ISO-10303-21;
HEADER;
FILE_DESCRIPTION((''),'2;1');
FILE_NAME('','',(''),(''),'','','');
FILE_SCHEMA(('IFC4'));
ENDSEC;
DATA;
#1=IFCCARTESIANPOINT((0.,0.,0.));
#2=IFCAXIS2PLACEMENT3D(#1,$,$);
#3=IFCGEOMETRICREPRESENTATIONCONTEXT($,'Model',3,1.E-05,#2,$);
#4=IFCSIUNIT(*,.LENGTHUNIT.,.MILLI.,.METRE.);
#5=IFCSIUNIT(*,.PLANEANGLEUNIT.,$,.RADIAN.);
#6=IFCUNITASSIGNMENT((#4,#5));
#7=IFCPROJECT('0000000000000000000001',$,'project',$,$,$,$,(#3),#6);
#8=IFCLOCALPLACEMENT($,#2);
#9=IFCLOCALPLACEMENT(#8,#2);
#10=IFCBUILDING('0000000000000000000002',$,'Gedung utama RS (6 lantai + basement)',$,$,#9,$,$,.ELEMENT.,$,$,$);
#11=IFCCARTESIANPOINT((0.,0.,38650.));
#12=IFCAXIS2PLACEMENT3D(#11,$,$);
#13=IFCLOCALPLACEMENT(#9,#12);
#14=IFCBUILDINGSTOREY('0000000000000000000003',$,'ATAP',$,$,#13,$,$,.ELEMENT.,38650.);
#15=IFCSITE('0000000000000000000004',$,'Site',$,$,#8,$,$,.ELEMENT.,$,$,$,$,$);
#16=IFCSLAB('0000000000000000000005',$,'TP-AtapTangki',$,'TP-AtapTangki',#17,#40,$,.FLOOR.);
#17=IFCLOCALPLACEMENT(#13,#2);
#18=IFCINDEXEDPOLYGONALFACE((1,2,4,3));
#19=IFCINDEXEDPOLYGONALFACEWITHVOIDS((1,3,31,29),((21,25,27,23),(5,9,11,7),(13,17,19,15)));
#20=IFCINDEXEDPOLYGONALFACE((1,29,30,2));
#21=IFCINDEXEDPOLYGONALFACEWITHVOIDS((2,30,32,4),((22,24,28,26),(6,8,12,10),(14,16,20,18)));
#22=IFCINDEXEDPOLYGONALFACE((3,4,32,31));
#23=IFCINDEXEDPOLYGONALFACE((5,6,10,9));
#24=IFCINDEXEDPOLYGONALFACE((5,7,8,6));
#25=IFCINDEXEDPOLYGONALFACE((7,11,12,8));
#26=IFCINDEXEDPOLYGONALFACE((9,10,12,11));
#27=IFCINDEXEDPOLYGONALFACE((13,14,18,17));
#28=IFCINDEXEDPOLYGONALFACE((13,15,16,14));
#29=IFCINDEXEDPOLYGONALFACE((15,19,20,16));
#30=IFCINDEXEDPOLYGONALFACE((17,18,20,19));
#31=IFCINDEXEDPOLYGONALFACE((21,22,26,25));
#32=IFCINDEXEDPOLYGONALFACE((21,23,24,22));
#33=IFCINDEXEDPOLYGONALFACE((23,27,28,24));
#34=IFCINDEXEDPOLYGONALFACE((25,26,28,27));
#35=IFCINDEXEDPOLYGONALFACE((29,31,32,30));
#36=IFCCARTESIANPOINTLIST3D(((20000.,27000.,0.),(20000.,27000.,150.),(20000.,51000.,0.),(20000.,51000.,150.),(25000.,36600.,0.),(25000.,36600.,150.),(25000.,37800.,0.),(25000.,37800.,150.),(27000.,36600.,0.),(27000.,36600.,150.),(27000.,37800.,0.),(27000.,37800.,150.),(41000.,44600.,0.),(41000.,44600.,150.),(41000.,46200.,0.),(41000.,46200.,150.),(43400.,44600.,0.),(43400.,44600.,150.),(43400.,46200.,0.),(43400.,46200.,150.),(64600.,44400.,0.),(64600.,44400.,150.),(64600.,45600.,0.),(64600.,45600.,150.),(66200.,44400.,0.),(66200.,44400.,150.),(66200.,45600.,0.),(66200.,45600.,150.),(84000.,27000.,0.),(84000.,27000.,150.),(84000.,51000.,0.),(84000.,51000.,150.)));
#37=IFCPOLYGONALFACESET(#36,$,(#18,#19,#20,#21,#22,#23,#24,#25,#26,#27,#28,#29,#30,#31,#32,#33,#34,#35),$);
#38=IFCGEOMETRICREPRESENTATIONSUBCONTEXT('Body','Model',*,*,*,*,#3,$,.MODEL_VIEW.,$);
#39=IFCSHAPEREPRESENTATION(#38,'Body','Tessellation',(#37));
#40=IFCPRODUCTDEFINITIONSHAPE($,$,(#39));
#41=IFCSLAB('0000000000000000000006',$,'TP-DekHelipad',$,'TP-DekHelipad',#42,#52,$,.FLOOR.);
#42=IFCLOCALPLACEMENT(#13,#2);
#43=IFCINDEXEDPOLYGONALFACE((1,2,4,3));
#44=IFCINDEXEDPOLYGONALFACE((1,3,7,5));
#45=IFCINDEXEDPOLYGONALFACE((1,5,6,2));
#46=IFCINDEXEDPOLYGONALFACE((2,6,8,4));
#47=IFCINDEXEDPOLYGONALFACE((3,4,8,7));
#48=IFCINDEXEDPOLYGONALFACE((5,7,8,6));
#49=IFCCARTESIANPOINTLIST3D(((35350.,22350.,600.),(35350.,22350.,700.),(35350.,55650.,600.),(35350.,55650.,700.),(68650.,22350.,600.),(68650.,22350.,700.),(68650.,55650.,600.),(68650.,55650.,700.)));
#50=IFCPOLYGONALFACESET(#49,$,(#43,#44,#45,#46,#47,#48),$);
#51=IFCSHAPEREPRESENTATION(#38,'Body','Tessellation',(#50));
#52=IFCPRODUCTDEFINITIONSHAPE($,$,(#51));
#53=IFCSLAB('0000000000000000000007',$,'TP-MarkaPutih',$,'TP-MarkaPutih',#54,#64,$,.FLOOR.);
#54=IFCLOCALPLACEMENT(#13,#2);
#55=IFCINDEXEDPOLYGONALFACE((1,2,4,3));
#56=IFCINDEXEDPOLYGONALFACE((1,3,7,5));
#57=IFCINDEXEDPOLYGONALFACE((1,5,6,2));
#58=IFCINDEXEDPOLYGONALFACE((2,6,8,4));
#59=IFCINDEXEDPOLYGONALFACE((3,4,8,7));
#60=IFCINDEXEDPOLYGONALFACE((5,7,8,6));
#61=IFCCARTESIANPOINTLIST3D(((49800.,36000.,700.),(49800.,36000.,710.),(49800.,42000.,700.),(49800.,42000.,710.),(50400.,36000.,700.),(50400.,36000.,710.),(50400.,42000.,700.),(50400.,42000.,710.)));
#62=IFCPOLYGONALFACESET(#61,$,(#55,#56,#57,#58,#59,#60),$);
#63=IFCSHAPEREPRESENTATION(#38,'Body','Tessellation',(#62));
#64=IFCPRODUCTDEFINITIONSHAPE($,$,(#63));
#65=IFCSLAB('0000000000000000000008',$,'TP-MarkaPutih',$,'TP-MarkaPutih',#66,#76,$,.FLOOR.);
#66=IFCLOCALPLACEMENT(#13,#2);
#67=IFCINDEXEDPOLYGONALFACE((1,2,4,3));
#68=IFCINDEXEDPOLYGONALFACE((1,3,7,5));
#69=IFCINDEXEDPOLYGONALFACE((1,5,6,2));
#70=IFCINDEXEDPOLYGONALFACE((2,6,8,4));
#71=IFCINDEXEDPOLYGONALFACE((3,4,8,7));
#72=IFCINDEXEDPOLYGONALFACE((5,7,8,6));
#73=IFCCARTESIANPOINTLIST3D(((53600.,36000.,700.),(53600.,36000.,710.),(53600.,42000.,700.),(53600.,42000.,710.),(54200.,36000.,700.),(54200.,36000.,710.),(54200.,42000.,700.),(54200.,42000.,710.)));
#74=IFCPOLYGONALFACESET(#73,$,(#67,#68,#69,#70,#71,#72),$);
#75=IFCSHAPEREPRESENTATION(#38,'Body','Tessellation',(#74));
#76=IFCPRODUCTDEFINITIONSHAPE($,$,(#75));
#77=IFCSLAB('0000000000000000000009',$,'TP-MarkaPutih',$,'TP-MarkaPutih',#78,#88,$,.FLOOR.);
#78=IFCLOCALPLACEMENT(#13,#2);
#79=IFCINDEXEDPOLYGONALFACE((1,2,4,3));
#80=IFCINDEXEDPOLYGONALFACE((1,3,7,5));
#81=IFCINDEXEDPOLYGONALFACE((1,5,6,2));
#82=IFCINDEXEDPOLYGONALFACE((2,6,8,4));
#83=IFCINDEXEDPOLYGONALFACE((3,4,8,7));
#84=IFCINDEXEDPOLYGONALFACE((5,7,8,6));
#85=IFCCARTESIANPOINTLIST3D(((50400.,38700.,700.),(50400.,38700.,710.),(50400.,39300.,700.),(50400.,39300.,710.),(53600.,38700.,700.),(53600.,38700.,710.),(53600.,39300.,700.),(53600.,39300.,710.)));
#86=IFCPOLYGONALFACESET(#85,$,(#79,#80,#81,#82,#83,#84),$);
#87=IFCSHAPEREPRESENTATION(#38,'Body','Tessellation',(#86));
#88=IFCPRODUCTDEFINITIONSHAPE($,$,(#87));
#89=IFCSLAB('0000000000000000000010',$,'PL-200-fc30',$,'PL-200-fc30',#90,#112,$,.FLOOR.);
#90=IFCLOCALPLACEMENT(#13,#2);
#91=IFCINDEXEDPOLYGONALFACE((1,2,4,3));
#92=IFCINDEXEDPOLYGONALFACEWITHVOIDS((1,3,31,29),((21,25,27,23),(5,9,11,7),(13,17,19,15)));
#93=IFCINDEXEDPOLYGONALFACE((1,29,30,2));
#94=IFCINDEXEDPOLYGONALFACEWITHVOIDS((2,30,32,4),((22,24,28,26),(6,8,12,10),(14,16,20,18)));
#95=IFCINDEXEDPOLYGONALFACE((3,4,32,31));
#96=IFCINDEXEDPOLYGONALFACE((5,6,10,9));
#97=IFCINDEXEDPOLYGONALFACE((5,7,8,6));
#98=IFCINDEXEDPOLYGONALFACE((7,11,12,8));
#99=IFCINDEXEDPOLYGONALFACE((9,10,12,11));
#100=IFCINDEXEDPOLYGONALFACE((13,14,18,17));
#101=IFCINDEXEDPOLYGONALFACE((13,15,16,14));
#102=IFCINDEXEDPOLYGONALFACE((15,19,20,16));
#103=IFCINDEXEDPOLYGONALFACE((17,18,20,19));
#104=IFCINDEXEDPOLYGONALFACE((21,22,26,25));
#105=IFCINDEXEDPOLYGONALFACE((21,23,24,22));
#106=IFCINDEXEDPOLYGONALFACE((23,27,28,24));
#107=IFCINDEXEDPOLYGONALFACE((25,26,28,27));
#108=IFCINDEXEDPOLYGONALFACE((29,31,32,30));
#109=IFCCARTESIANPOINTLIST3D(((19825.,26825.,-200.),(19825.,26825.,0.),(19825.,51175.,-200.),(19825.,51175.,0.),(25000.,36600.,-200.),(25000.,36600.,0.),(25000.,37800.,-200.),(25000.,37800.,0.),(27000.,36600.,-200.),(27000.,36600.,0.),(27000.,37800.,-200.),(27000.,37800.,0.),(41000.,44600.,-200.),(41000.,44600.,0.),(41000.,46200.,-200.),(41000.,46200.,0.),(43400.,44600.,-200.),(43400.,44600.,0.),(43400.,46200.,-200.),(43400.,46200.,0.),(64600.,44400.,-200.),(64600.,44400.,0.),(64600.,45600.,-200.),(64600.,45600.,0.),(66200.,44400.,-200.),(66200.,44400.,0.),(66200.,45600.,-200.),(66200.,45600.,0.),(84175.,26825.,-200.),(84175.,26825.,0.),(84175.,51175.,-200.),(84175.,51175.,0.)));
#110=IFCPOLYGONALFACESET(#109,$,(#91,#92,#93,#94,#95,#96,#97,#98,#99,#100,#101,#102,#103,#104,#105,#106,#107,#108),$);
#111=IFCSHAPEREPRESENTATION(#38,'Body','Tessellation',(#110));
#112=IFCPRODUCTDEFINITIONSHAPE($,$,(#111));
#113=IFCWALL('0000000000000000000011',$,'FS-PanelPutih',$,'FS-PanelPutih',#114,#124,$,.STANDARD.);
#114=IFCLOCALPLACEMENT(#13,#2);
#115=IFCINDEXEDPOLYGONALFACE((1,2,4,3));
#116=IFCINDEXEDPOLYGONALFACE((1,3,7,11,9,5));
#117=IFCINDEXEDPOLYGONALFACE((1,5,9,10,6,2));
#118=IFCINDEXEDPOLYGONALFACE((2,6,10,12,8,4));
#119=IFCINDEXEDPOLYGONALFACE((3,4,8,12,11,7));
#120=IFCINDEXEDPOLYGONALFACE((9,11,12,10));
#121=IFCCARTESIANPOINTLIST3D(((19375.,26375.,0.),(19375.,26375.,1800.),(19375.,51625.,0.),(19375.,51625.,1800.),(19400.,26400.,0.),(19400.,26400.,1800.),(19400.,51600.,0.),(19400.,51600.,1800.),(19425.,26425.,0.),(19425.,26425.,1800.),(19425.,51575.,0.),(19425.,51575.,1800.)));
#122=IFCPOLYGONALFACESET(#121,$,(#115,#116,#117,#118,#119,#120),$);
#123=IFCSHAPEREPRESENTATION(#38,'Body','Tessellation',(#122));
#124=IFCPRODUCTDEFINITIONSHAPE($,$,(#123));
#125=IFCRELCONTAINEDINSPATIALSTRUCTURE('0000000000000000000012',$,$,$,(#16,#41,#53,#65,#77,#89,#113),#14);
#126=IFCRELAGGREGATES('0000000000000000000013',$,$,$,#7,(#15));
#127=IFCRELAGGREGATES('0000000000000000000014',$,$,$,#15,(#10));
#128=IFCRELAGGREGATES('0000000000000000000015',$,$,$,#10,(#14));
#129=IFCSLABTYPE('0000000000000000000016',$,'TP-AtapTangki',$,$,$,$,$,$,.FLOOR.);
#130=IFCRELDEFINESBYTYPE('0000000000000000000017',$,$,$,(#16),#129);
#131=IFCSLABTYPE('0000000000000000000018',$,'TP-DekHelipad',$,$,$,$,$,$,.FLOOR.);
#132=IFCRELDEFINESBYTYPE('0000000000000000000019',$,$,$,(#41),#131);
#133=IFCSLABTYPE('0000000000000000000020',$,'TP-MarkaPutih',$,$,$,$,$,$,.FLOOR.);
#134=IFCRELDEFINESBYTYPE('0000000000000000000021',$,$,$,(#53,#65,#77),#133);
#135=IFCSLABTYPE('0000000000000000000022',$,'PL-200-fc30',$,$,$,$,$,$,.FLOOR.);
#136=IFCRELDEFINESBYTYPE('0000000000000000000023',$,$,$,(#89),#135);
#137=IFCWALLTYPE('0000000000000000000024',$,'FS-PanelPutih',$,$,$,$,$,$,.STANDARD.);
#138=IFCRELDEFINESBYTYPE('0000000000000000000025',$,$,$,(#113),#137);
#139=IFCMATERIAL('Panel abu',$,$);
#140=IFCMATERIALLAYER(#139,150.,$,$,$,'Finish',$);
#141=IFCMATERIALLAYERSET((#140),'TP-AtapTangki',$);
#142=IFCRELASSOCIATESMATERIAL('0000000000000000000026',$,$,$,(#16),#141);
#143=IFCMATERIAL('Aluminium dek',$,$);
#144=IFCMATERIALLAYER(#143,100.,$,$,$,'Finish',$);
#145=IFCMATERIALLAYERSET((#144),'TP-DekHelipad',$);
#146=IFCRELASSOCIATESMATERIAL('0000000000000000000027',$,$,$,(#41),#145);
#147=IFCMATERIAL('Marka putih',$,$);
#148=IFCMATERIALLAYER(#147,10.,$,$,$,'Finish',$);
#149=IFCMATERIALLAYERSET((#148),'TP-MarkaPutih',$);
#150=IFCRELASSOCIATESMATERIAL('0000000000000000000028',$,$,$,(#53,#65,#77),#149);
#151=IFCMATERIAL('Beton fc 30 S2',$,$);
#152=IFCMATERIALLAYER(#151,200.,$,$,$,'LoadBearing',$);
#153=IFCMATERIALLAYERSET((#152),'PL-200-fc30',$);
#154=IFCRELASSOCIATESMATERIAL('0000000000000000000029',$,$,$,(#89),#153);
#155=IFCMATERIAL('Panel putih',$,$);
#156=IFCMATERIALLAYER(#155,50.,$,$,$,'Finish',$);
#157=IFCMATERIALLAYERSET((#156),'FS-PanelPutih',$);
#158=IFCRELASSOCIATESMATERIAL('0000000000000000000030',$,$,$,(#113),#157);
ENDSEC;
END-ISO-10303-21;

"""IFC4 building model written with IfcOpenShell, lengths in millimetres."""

from ifc_helpers import new_model, si_unit, frame, origin, place, context, subcontext, project, spatial, polyline, outline, extrude, material, layer, layer_set, layer_usage, type_object, element, save


model = new_model("IFC4")

# Units and contexts
model_context = context("Model", 3, precision=1e-05, world=origin())
body_context = subcontext(model_context, "Body", "Model", "MODEL_VIEW")
ifc_project = project(units=[si_unit("LENGTHUNIT", "METRE", prefix="MILLI"), si_unit("PLANEANGLEUNIT", "RADIAN")], contexts=[model_context])

# Site, building, storey
site_placement = place(None, origin())
site = spatial("IfcSite", under=ifc_project, at=site_placement, Name="Site", CompositionType="ELEMENT")
building_placement = place(site_placement, origin())
building = spatial("IfcBuilding", under=site, at=building_placement, Name="Gedung utama RS (6 lantai + basement)", CompositionType="ELEMENT")
storey_placement = place(building_placement, frame((0.0, 0.0, 38650.0)))
storey = spatial("IfcBuildingStorey", under=building, at=storey_placement, Name="ATAP", CompositionType="ELEMENT", Elevation=38650.0)

# Shared definitions
ifc_material_1 = material(Name="Beton fc 30 S2")

# Slabs
ifc_material_2 = material(Name="Panel abu")
ifc_layer_1 = layer(ifc_material_2, 150.0, Category="Finish")
ifc_layer_set_1 = layer_set([ifc_layer_1], Name="TP-AtapTangki")
ifc_layer_usage_1 = layer_usage(ifc_layer_set_1, "AXIS3", "NEGATIVE", 150.0)
slab_type_1 = type_object("IfcSlabType", Name="TP-AtapTangki", PredefinedType="FLOOR")
slab_1_placement = place(storey_placement, origin())
element("IfcSlab", 1, at=slab_1_placement, inside=storey, type_object=slab_type_1, material=ifc_layer_usage_1, Name="TP-AtapTangki", ObjectType="TP-AtapTangki", PredefinedType="FLOOR", context=body_context, shape_type="SweptSolid", body=[
    extrude(outline(polyline([(84000.0, 27000.0), (84000.0, 51000.0), (20000.0, 51000.0), (20000.0, 27000.0), (84000.0, 27000.0)]), holes=[polyline([(27000.0, 36600.0), (27000.0, 37800.0), (25000.0, 37800.0), (25000.0, 36600.0), (27000.0, 36600.0)]), polyline([(43400.0, 44600.0), (43400.0, 46200.0), (41000.0, 46200.0), (41000.0, 44600.0), (43400.0, 44600.0)]), polyline([(66200.0, 44400.0), (66200.0, 45600.0), (64600.0, 45600.0), (64600.0, 44400.0), (66200.0, 44400.0)])]), origin(), (0.0, 0.0, 1.0), 150.0),
])
ifc_material_3 = material(Name="Aluminium dek")
ifc_layer_2 = layer(ifc_material_3, 100.0, Category="Finish")
ifc_layer_set_2 = layer_set([ifc_layer_2], Name="TP-DekHelipad")
ifc_layer_usage_2 = layer_usage(ifc_layer_set_2, "AXIS3", "NEGATIVE", 700.0)
slab_type_2 = type_object("IfcSlabType", Name="TP-DekHelipad", PredefinedType="FLOOR")
slab_2_placement = place(storey_placement, origin())
element("IfcSlab", 2, at=slab_2_placement, inside=storey, type_object=slab_type_2, material=ifc_layer_usage_2, Name="TP-DekHelipad", ObjectType="TP-DekHelipad", PredefinedType="FLOOR", context=body_context, shape_type="SweptSolid", body=[
    extrude(outline(polyline([(68650.0, 22350.0), (68650.0, 55650.0), (35350.0, 55650.0), (35350.0, 22350.0), (68650.0, 22350.0)])), frame((0.0, 0.0, 600.0)), (0.0, 0.0, 1.0), 100.0),
])
ifc_material_4 = material(Name="Marka putih")
ifc_layer_3 = layer(ifc_material_4, 10.0, Category="Finish")
ifc_layer_set_3 = layer_set([ifc_layer_3], Name="TP-MarkaPutih")
ifc_layer_usage_3 = layer_usage(ifc_layer_set_3, "AXIS3", "NEGATIVE", 710.0)
slab_type_3 = type_object("IfcSlabType", Name="TP-MarkaPutih", PredefinedType="FLOOR")
slab_3_placement = place(storey_placement, origin())
element("IfcSlab", 3, at=slab_3_placement, inside=storey, type_object=slab_type_3, material=ifc_layer_usage_3, Name="TP-MarkaPutih", ObjectType="TP-MarkaPutih", PredefinedType="FLOOR", context=body_context, shape_type="SweptSolid", body=[
    extrude(outline(polyline([(50400.0, 36000.0), (50400.0, 42000.0), (49800.0, 42000.0), (49800.0, 36000.0), (50400.0, 36000.0)])), frame((0.0, 0.0, 700.0)), (0.0, 0.0, 1.0), 10.0),
])
slab_4_placement = place(storey_placement, origin())
element("IfcSlab", 4, at=slab_4_placement, inside=storey, type_object=slab_type_3, material=ifc_layer_usage_3, Name="TP-MarkaPutih", ObjectType="TP-MarkaPutih", PredefinedType="FLOOR", context=body_context, shape_type="SweptSolid", body=[
    extrude(outline(polyline([(54200.0, 36000.0), (54200.0, 42000.0), (53600.0, 42000.0), (53600.0, 36000.0), (54200.0, 36000.0)])), frame((0.0, 0.0, 700.0)), (0.0, 0.0, 1.0), 10.0),
])
slab_5_placement = place(storey_placement, origin())
element("IfcSlab", 5, at=slab_5_placement, inside=storey, type_object=slab_type_3, material=ifc_layer_usage_3, Name="TP-MarkaPutih", ObjectType="TP-MarkaPutih", PredefinedType="FLOOR", context=body_context, shape_type="SweptSolid", body=[
    extrude(outline(polyline([(53600.0, 38700.0), (53600.0, 39300.0), (50400.0, 39300.0), (50400.0, 38700.0), (53600.0, 38700.0)])), frame((0.0, 0.0, 700.0)), (0.0, 0.0, 1.0), 10.0),
])

# Slab, openings
ifc_layer_4 = layer(ifc_material_1, 200.0, Category="LoadBearing")
ifc_layer_set_4 = layer_set([ifc_layer_4], Name="PL-200-fc30")
ifc_layer_usage_4 = layer_usage(ifc_layer_set_4, "AXIS3", "NEGATIVE", 0.0)
slab_type_4 = type_object("IfcSlabType", Name="PL-200-fc30", PredefinedType="FLOOR")
slab_6_placement = place(storey_placement, origin())
slab_6 = element("IfcSlab", 6, at=slab_6_placement, inside=storey, type_object=slab_type_4, material=ifc_layer_usage_4, Name="PL-200-fc30", ObjectType="PL-200-fc30", PredefinedType="FLOOR", context=body_context, shape_type="SweptSolid", body=[
    extrude(outline(polyline([(84175.0, 51175.0), (19825.0, 51175.0), (19825.0, 26825.0), (84175.0, 26825.0), (84175.0, 51175.0)])), frame((0.0, 0.0, -200.0)), (0.0, 0.0, 1.0), 200.0),
])
opening_1_placement = place(slab_6_placement, frame((0.0, 0.0, -25700.0)))
element("IfcOpeningElement", 7, at=opening_1_placement, cuts=slab_6, PredefinedType="OPENING", context=body_context, shape_type="SweptSolid", body=[
    extrude(outline(polyline([(27000.0, 36600.0), (27000.0, 37800.0), (25000.0, 37800.0), (25000.0, 36600.0), (27000.0, 36600.0)])), origin(), (0.0, 0.0, 1.0), 25800.0),
])
opening_2_placement = place(slab_6_placement, frame((0.0, 0.0, -25700.0)))
element("IfcOpeningElement", 8, at=opening_2_placement, cuts=slab_6, PredefinedType="OPENING", context=body_context, shape_type="SweptSolid", body=[
    extrude(outline(polyline([(43400.0, 44600.0), (43400.0, 46200.0), (41000.0, 46200.0), (41000.0, 44600.0), (43400.0, 44600.0)])), origin(), (0.0, 0.0, 1.0), 25800.0),
])
opening_3_placement = place(slab_6_placement, frame((0.0, 0.0, -25700.0)))
element("IfcOpeningElement", 9, at=opening_3_placement, cuts=slab_6, PredefinedType="OPENING", context=body_context, shape_type="SweptSolid", body=[
    extrude(outline(polyline([(66200.0, 44400.0), (66200.0, 45600.0), (64600.0, 45600.0), (64600.0, 44400.0), (66200.0, 44400.0)])), origin(), (0.0, 0.0, 1.0), 25800.0),
])

# Wall
ifc_material_5 = material(Name="Panel putih")
ifc_layer_5 = layer(ifc_material_5, 50.0, Category="Finish")
ifc_layer_set_5 = layer_set([ifc_layer_5], Name="FS-PanelPutih")
ifc_layer_usage_5 = layer_usage(ifc_layer_set_5, "AXIS2", "NEGATIVE", 25.0)
wall_type = type_object("IfcWallType", Name="FS-PanelPutih", PredefinedType="STANDARD")
wall_placement = place(storey_placement, frame((19400.0, 26400.0, 0.0), z_axis=(0.0, 0.0, 1.0), x_axis=(0.0, 1.0, 0.0)))
element("IfcWall", 10, at=wall_placement, inside=storey, type_object=wall_type, material=ifc_layer_usage_5, Name="FS-PanelPutih", ObjectType="FS-PanelPutih", PredefinedType="STANDARD", context=body_context, shape_type="SweptSolid", body=[
    extrude(outline(polyline([(25.0, -25.0), (0.0, 0.0), (-25.0, 25.0), (25225.0, 25.0), (25200.0, 0.0), (25175.0, -25.0), (25.0, -25.0)])), origin(), (0.0, 0.0, 1.0), 1800.0),
])

save(model, "model.ifc")
